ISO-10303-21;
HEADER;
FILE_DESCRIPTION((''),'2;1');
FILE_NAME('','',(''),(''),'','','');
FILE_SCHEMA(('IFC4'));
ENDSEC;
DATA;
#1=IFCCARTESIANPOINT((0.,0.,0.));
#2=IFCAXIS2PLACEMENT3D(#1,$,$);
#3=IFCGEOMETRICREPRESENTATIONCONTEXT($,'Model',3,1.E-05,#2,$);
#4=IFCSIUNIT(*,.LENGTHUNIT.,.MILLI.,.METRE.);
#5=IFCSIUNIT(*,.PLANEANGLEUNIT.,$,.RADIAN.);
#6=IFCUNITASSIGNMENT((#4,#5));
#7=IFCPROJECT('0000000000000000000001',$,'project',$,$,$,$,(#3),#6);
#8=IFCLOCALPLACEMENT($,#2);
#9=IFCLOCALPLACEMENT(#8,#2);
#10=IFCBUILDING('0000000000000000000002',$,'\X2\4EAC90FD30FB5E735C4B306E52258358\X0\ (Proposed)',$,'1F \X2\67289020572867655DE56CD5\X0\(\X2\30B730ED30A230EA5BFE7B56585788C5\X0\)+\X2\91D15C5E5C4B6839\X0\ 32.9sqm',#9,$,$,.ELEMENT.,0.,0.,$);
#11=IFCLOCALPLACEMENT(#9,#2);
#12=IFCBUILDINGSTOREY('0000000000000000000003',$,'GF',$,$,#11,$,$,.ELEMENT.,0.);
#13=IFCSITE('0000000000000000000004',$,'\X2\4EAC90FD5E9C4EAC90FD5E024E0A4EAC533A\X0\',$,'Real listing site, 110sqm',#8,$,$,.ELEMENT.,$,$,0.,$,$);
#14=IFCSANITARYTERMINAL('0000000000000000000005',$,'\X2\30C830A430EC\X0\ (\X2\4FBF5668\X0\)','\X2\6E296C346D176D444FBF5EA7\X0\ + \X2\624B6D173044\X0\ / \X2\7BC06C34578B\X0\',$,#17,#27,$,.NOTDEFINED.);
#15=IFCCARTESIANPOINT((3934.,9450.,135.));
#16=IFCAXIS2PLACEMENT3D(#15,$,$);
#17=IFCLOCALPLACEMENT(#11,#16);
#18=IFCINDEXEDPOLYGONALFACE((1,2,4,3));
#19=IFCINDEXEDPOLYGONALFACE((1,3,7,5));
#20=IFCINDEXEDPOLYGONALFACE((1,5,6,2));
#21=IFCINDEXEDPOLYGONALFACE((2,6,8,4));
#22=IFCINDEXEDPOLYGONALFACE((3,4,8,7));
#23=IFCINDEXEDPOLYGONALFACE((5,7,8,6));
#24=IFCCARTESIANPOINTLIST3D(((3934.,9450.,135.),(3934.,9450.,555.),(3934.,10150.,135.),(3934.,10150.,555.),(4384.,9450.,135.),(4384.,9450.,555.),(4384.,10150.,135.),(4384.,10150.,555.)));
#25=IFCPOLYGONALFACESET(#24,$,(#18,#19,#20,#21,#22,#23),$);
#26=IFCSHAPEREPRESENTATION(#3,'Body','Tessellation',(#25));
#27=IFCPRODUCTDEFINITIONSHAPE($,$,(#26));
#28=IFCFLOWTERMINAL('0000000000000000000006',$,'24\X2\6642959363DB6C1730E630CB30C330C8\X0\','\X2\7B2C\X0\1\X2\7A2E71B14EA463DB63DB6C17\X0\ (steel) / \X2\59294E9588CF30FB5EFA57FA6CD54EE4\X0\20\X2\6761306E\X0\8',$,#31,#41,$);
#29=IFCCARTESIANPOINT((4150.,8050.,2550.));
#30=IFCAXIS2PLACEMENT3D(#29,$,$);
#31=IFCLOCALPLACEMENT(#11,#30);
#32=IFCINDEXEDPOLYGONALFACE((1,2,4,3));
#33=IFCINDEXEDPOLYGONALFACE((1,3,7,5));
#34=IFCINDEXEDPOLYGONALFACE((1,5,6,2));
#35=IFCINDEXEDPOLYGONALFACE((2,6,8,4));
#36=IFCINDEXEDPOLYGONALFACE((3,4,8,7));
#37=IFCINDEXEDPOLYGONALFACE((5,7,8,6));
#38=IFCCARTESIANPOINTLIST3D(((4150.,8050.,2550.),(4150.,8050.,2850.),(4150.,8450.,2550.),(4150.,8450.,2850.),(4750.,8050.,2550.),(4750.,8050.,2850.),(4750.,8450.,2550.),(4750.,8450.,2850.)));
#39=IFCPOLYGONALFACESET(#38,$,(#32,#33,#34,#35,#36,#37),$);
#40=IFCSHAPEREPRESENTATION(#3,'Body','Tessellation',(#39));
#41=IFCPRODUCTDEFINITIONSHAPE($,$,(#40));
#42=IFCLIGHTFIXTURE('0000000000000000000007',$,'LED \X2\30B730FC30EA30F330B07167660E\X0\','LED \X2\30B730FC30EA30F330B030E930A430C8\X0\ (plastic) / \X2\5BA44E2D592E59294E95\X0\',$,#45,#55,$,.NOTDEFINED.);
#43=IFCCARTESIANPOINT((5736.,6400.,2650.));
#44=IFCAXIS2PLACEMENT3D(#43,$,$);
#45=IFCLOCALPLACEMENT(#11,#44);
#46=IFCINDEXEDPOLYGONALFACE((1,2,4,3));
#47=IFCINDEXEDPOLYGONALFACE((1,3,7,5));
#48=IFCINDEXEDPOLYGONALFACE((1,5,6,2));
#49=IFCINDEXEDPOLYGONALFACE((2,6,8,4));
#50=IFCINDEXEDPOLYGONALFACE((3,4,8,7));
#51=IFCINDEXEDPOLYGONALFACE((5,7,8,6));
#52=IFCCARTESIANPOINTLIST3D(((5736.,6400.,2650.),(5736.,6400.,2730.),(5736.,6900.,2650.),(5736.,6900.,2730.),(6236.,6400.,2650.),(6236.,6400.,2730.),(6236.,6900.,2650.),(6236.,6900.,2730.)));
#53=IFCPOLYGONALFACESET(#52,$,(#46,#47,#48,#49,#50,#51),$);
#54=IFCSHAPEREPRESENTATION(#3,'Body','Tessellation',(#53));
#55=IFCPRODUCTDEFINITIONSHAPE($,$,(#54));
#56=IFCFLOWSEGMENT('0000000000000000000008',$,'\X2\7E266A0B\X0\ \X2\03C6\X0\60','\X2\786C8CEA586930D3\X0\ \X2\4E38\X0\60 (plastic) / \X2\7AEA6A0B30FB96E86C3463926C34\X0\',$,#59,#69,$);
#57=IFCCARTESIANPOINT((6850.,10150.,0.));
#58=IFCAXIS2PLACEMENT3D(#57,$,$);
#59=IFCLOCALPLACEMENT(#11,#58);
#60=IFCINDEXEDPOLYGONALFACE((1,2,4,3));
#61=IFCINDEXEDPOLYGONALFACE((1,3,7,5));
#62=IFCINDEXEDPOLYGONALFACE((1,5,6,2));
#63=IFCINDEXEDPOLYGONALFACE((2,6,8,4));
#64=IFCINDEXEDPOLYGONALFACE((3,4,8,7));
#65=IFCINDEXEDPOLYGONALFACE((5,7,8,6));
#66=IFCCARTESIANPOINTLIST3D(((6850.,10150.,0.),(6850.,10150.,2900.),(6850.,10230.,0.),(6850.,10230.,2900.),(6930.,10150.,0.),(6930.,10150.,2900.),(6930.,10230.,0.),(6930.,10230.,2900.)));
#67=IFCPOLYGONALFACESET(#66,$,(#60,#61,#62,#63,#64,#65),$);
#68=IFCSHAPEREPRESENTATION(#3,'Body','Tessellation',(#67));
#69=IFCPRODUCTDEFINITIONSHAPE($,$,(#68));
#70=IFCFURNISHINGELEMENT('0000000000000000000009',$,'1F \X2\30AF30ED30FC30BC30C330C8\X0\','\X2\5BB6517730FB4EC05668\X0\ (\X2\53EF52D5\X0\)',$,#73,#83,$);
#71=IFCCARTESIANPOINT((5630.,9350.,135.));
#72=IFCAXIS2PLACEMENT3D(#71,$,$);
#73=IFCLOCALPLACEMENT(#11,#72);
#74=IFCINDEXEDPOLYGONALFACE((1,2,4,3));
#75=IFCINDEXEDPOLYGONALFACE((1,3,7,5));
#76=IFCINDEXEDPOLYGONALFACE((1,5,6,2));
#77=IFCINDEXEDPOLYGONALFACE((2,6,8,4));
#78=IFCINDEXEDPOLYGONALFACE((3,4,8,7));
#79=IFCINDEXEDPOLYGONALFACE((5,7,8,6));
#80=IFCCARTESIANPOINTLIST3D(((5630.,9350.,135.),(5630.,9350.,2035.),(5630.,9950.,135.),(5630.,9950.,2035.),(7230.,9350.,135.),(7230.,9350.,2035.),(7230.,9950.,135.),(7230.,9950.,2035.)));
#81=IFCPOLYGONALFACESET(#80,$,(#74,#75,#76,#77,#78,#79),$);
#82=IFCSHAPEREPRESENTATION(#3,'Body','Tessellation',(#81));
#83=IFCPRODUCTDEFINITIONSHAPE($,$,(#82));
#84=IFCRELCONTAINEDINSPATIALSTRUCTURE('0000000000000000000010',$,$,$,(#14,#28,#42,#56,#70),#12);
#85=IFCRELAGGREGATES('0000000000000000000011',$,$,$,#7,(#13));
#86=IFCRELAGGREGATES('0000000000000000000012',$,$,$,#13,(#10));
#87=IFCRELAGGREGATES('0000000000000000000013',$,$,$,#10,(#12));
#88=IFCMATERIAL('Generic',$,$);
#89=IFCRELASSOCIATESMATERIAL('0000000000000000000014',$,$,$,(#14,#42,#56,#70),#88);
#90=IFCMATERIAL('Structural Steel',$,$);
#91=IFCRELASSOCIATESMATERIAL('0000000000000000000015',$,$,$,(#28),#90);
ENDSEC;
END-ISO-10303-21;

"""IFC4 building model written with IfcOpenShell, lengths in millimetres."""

from ifc_helpers import new_model, si_unit, frame, frame_2d, origin, place, context, project, spatial, rectangle, extrude, material, element, save


model = new_model("IFC4")

# Units and contexts
model_context = context("Model", 3, precision=1e-05, world=origin())
ifc_project = project(units=[si_unit("LENGTHUNIT", "METRE", prefix="MILLI"), si_unit("PLANEANGLEUNIT", "RADIAN")], contexts=[model_context])

# Site, building, storey
site_placement = place(None, origin())
site = spatial("IfcSite", under=ifc_project, at=site_placement, Name="京都府京都市上京区", ObjectType="Real listing site, 110sqm", CompositionType="ELEMENT", RefElevation=0.0)
building_placement = place(site_placement, origin())
building = spatial("IfcBuilding", under=site, at=building_placement, Name="京都・平屋の別荘 (Proposed)", ObjectType="1F 木造在来工法(シロアリ対策塗装)+金属屋根 32.9sqm", CompositionType="ELEMENT", ElevationOfRefHeight=0.0, ElevationOfTerrain=0.0)
storey_placement = place(building_placement, origin())
storey = spatial("IfcBuildingStorey", under=building, at=storey_placement, Name="GF", CompositionType="ELEMENT", Elevation=0.0)

# Shared definitions
ifc_material_1 = material(Name="Generic")

# Sanitary terminal
sanitary_terminal_1_placement = place(storey_placement, frame((3934.0, 9450.0, 135.0)))
element("IfcSanitaryTerminal", 1, at=sanitary_terminal_1_placement, inside=storey, material=ifc_material_1, Name="トイレ (便器)", Description="温水洗浄便座 + 手洗い / 節水型", PredefinedType="NOTDEFINED", context=model_context, shape_type="SweptSolid", body=[
    extrude(rectangle(XDim=450.0, YDim=700.0, at=frame_2d((225.0, 350.0))), frame((3934.0, 9450.0, 135.0)), (0.0, 0.0, 1.0), 420.0),
])

# Flow terminal
ifc_material_2 = material(Name="Structural Steel")
flow_terminal_placement = place(storey_placement, frame((4150.0, 8050.0, 2550.0)))
element("IfcFlowTerminal", 2, at=flow_terminal_placement, inside=storey, material=ifc_material_2, Name="24時間換気ユニット", Description="第1種熱交換換気 (steel) / 天井裏・建基法令20条の8", context=model_context, shape_type="SweptSolid", body=[
    extrude(rectangle(XDim=600.0, YDim=400.0, at=frame_2d((300.0, 200.0))), frame((4150.0, 8050.0, 2550.0)), (0.0, 0.0, 1.0), 300.0),
])

# Light fixture
light_fixture_placement = place(storey_placement, frame((5736.0, 6400.0, 2650.0)))
element("IfcLightFixture", 3, at=light_fixture_placement, inside=storey, material=ifc_material_1, Name="LED シーリング照明", Description="LED シーリングライト (plastic) / 室中央天井", PredefinedType="NOTDEFINED", context=model_context, shape_type="SweptSolid", body=[
    extrude(rectangle(XDim=500.0, YDim=500.0, at=frame_2d((250.0, 250.0))), frame((5736.0, 6400.0, 2650.0)), (0.0, 0.0, 1.0), 80.0),
])

# Flow segment
flow_segment_placement = place(storey_placement, frame((6850.0, 10150.0, 0.0)))
element("IfcFlowSegment", 4, at=flow_segment_placement, inside=storey, material=ifc_material_1, Name="縦樋 φ60", Description="硬質塩ビ 丸60 (plastic) / 竪樋・雨水排水", context=model_context, shape_type="SweptSolid", body=[
    extrude(rectangle(XDim=80.0, YDim=80.0, at=frame_2d((40.0, 40.0))), frame((6850.0, 10150.0, 0.0)), (0.0, 0.0, 1.0), 2900.0),
])

# Furnishing element
furnishing_placement = place(storey_placement, frame((5630.0, 9350.0, 135.0)))
element("IfcFurnishingElement", 5, at=furnishing_placement, inside=storey, material=ifc_material_1, Name="1F クローゼット", Description="家具・什器 (可動)", context=model_context, shape_type="SweptSolid", body=[
    extrude(rectangle(XDim=1600.0, YDim=600.0, at=frame_2d((800.0, 300.0))), frame((5630.0, 9350.0, 135.0)), (0.0, 0.0, 1.0), 1900.0),
])

save(model, "model.ifc")
